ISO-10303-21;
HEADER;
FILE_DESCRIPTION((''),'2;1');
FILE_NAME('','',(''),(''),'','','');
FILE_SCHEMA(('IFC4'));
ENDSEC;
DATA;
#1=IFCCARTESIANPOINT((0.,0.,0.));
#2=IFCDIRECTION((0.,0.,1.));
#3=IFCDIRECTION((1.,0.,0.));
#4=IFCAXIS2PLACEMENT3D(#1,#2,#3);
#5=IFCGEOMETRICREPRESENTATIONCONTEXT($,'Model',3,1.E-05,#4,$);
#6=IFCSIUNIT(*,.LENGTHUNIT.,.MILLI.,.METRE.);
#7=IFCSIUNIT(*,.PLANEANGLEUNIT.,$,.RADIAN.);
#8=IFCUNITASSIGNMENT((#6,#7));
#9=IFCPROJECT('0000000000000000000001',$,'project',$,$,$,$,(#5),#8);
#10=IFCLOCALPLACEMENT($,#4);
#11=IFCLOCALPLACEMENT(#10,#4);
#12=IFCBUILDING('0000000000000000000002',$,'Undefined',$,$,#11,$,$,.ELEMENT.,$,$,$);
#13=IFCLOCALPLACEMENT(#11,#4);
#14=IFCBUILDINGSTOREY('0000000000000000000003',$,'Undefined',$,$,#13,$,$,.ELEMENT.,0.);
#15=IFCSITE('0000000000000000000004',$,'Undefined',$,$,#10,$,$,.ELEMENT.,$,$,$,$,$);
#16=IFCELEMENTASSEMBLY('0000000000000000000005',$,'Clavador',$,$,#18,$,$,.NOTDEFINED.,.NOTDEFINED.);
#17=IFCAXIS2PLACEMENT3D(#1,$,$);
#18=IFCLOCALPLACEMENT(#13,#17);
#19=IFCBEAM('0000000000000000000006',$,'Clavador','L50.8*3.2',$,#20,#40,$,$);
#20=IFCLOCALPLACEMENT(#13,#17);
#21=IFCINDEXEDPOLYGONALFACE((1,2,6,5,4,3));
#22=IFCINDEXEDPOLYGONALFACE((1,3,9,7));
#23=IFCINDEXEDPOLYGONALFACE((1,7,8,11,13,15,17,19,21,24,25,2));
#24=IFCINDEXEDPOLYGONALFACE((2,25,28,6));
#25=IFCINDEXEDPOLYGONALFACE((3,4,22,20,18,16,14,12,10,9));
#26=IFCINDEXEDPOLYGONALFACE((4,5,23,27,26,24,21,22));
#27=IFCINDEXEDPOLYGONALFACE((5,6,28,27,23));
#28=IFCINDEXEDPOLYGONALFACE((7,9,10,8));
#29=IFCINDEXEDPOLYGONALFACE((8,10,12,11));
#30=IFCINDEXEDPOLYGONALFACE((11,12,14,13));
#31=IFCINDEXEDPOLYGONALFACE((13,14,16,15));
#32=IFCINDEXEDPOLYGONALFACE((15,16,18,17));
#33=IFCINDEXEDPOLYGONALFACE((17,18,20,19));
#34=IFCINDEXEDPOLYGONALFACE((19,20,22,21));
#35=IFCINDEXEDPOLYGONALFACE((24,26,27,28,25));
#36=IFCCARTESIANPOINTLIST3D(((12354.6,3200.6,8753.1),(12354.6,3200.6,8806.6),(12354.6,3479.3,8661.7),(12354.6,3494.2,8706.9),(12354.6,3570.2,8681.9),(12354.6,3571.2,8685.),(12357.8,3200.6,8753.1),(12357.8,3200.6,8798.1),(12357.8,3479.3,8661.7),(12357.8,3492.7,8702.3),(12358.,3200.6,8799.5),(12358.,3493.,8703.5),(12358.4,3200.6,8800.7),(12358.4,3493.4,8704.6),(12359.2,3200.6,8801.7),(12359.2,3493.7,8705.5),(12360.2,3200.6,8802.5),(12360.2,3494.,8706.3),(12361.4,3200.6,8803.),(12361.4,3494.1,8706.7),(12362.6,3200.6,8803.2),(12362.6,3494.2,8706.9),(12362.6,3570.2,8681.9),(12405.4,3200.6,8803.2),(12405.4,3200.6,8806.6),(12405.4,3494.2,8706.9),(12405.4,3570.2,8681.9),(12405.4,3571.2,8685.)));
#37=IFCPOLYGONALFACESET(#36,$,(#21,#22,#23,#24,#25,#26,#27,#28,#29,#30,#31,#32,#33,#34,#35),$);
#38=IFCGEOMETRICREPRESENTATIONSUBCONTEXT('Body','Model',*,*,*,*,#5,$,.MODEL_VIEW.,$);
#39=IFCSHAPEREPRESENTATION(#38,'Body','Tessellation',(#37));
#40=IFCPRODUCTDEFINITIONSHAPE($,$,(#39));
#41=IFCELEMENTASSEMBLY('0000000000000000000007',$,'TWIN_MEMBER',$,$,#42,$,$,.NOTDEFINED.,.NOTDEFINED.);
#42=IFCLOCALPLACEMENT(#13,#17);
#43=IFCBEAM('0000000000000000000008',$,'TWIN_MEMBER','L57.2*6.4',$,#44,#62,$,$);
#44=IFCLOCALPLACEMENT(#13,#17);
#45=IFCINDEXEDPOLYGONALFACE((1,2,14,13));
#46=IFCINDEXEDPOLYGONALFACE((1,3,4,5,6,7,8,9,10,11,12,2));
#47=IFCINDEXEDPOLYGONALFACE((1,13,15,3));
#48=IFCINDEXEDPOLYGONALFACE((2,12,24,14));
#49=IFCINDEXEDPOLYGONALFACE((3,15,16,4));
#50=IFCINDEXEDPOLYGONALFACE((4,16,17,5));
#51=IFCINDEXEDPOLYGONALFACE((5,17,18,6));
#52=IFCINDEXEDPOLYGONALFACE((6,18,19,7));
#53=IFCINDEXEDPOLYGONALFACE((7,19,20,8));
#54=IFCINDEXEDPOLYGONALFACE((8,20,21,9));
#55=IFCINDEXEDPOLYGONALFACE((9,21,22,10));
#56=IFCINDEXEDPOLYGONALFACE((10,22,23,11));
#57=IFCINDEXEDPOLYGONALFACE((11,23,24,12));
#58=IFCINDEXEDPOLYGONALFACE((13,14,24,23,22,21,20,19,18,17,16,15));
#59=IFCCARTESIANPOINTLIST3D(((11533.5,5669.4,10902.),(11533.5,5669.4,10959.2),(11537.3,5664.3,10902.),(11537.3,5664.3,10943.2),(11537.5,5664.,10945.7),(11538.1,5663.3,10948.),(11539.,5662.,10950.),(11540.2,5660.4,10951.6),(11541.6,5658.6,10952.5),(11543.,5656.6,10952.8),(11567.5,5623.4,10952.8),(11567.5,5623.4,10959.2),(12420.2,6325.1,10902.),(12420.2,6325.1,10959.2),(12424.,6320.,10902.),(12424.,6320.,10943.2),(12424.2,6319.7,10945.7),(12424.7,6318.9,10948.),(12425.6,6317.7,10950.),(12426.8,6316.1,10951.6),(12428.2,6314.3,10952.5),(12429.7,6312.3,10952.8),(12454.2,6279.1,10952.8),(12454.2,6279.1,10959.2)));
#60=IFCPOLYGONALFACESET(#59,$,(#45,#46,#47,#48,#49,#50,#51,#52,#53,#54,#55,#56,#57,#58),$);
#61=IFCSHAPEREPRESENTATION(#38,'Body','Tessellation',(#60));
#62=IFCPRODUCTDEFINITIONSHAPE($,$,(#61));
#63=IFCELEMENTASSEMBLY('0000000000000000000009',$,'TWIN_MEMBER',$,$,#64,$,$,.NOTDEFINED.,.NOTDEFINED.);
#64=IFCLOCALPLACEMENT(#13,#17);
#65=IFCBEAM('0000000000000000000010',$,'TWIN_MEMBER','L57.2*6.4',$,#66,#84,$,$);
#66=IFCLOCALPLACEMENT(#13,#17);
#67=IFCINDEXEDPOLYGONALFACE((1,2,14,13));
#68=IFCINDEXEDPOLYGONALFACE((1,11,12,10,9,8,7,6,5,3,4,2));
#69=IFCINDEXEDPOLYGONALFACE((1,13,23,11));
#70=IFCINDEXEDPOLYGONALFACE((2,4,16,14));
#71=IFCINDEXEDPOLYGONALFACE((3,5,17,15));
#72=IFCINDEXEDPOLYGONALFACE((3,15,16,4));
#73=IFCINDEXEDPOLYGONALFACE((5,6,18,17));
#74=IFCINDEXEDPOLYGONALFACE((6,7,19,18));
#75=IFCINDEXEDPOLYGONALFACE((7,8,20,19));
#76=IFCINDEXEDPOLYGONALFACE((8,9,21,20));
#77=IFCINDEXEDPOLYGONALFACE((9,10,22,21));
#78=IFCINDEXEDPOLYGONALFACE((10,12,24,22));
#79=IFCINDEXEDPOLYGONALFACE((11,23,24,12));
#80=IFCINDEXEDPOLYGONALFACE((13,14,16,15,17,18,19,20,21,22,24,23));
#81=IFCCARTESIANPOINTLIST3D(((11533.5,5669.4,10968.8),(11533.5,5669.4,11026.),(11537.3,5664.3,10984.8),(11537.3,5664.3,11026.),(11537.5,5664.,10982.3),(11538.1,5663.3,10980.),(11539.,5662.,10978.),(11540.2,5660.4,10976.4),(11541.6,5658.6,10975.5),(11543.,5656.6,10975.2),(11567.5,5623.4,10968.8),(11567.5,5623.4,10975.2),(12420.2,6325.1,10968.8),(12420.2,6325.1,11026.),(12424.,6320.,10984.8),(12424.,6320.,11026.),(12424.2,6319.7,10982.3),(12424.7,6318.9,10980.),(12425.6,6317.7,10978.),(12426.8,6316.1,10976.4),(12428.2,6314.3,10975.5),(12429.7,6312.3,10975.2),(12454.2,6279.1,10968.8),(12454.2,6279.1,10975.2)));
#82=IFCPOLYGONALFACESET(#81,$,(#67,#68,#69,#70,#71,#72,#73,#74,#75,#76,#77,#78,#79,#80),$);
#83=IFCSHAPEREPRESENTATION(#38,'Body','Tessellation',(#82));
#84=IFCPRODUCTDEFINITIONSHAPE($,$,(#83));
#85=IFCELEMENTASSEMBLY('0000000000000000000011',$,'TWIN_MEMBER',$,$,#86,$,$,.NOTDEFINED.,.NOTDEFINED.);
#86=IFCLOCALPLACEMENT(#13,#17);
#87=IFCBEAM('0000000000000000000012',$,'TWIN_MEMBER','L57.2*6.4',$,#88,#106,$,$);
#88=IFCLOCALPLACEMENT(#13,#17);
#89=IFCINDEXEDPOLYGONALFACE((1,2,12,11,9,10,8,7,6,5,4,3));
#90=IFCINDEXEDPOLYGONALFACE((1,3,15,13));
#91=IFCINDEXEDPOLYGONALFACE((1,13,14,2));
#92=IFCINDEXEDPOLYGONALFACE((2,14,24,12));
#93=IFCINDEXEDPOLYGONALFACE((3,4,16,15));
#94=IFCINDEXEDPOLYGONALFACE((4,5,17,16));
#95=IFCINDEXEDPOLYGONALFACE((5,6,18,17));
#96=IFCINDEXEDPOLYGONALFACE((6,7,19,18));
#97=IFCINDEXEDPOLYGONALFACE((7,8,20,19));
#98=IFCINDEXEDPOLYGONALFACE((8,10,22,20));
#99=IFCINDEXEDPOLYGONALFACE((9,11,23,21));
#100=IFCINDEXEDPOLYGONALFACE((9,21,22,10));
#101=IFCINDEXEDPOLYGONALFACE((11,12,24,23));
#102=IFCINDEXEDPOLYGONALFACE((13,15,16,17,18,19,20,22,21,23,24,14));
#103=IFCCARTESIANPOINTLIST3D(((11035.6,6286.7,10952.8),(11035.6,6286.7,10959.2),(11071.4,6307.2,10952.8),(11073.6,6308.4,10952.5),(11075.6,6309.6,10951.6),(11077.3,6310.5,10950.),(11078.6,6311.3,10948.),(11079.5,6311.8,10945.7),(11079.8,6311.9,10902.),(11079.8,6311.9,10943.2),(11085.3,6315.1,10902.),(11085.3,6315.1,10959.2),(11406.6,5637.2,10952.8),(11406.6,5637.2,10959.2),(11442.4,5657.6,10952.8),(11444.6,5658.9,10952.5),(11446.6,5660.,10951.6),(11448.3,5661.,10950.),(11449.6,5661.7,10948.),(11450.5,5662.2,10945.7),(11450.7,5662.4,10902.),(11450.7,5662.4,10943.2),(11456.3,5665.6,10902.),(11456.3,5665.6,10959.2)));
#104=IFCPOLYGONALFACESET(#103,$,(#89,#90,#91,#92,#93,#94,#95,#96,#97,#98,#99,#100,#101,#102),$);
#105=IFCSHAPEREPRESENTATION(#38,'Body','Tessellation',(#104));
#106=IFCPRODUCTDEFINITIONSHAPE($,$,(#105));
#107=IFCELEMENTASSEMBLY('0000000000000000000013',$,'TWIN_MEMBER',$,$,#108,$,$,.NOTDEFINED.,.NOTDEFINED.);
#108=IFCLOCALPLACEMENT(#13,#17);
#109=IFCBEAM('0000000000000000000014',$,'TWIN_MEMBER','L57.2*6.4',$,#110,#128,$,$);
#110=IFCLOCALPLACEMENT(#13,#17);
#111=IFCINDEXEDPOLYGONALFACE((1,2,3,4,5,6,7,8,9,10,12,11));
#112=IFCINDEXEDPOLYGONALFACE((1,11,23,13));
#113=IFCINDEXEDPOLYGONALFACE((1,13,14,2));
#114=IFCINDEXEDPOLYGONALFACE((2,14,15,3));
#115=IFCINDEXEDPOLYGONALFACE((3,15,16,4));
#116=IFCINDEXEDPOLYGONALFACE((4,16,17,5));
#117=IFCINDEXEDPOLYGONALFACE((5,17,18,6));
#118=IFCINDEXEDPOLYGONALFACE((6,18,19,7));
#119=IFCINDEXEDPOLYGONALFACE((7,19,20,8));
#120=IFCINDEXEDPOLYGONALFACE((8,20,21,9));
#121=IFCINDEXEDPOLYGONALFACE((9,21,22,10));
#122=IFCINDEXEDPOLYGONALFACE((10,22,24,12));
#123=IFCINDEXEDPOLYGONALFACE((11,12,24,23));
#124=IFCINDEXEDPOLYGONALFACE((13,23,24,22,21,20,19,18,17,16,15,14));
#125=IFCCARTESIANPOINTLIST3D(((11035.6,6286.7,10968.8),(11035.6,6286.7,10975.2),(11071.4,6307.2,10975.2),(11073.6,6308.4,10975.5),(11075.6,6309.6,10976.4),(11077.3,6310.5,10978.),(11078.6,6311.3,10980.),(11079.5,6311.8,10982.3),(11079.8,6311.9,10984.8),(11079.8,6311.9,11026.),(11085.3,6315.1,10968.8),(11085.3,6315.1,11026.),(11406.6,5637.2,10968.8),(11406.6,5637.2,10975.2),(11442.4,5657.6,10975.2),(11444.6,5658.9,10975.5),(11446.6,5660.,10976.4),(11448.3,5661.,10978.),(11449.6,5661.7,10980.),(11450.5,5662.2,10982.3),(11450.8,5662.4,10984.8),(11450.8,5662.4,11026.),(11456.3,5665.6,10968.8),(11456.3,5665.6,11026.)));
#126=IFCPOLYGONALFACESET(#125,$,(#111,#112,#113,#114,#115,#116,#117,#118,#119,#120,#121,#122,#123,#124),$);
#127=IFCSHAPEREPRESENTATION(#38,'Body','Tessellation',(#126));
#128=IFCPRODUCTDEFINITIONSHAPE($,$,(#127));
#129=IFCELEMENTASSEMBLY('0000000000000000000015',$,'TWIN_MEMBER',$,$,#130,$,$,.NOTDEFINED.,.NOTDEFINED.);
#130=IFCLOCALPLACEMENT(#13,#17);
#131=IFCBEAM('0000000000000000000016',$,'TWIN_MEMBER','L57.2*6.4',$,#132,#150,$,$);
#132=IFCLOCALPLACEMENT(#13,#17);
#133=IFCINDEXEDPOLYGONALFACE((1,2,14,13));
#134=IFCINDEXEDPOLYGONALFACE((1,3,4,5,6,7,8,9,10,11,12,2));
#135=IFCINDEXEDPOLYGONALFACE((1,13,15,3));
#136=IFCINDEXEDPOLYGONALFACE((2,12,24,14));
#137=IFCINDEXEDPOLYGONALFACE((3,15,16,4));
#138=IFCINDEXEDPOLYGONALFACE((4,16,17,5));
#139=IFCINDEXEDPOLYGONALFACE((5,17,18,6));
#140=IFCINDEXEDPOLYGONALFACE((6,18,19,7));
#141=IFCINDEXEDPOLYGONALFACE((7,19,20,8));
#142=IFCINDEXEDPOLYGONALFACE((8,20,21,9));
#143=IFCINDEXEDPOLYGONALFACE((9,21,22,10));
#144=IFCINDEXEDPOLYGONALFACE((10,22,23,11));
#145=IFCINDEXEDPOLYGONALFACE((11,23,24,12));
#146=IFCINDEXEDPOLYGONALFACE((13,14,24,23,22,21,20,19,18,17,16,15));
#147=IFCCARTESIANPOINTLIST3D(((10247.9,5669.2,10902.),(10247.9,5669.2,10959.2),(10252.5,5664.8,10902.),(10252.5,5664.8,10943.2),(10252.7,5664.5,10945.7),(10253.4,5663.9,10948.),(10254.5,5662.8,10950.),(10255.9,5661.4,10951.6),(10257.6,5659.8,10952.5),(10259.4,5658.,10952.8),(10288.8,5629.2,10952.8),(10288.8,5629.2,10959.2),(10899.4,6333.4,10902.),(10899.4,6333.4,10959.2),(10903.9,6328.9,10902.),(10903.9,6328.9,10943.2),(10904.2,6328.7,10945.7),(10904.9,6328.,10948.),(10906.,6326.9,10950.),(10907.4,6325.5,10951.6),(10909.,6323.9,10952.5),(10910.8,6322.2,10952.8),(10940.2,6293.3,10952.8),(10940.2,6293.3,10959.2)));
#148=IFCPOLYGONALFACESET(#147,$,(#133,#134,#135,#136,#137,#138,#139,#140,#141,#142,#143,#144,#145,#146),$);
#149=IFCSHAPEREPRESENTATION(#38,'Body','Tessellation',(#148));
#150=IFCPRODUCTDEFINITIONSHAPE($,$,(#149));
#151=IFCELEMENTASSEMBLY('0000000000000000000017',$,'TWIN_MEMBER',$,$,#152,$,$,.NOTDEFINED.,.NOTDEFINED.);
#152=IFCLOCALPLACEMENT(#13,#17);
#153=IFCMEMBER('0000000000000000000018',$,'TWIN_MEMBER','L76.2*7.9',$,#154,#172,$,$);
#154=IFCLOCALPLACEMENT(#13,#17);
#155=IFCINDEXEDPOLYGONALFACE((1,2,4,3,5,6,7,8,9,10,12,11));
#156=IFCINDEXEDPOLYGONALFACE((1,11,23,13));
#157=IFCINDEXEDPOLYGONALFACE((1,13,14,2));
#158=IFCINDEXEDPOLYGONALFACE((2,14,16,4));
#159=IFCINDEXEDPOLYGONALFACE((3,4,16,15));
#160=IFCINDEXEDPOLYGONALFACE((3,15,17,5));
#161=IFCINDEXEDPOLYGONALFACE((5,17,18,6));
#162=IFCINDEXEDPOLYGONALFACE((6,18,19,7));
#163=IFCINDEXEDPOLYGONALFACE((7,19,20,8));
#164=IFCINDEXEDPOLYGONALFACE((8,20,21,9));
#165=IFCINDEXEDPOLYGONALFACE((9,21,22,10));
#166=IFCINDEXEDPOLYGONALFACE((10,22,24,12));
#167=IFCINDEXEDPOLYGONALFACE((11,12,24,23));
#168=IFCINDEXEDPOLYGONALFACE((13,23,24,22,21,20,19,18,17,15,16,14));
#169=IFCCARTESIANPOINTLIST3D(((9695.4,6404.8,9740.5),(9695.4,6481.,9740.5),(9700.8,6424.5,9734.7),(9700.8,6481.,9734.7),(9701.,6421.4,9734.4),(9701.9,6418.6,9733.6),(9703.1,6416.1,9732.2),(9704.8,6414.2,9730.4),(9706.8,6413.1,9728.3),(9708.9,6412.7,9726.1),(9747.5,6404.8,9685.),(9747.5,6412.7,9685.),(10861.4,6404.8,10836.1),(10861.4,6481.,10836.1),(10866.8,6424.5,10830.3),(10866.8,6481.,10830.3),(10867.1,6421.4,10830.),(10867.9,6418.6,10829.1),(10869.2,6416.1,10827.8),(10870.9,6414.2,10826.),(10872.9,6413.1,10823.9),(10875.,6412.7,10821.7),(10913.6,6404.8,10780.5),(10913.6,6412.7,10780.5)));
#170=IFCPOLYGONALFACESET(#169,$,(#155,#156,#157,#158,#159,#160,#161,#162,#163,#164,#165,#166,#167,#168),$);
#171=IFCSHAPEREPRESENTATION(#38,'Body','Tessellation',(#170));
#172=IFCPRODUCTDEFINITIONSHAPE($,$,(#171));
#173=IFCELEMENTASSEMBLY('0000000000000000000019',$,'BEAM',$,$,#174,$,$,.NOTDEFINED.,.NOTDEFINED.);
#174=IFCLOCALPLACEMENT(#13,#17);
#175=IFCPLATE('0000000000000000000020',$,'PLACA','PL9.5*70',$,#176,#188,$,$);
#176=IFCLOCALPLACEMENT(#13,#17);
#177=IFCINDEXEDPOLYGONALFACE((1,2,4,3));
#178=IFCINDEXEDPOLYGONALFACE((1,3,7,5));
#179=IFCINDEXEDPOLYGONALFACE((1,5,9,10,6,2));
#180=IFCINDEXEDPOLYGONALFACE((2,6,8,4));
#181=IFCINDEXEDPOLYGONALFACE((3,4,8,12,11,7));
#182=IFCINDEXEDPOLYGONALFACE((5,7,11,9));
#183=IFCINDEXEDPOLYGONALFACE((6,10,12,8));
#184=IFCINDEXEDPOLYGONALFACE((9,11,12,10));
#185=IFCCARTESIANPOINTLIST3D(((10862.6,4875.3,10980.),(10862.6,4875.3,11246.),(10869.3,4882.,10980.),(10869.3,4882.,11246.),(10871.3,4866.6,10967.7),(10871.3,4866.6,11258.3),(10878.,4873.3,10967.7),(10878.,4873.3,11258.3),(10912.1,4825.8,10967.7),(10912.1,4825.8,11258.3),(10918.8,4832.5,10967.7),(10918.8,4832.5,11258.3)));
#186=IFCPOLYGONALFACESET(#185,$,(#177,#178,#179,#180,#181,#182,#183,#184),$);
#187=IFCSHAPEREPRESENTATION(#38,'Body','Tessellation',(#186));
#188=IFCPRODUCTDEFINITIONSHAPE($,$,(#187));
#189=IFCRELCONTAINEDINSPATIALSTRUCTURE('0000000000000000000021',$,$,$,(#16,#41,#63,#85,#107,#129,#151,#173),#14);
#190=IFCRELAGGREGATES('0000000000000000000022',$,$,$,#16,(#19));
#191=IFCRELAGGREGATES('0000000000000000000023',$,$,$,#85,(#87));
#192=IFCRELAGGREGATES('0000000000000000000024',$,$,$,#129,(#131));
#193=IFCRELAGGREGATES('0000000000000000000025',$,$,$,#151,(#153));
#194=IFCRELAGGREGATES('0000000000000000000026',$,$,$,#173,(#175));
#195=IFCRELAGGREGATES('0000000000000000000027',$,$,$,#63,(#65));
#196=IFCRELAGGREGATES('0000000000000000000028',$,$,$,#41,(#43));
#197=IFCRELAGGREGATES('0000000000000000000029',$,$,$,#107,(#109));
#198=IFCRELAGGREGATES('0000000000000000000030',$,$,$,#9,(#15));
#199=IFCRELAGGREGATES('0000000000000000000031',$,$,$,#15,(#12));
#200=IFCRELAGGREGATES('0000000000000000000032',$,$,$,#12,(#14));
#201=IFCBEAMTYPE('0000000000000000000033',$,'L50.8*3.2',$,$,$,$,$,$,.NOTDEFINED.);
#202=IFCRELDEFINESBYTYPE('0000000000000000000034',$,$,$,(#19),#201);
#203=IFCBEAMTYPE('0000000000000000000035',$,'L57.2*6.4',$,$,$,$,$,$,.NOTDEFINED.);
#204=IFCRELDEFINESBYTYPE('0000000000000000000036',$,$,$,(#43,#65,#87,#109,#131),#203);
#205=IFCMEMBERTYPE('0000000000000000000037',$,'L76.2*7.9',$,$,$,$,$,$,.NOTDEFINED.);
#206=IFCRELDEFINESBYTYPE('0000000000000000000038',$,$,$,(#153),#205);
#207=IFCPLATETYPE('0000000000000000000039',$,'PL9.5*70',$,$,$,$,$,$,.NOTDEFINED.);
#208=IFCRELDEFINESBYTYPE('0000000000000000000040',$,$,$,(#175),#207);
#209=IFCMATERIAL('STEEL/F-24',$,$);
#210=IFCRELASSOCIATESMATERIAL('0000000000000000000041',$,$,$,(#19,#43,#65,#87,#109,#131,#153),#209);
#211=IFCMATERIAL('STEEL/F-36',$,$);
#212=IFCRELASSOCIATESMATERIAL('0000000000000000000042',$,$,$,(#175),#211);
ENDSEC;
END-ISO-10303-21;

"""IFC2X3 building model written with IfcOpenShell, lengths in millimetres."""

from ifc_helpers import new_model, si_unit, frame, origin_with_axes, origin_2d_with_axis, place, context, subcontext, project, spatial, polyline, l_section, outline, extrude, boolean, halfspace, material, type_object, element, aggregate, save


model = new_model("IFC2X3")

# Units and contexts
model_context = context("Model", 3, precision=1e-05, world=origin_with_axes())
body_context = subcontext(model_context, "Body", "Model", "MODEL_VIEW")
ifc_project = project(units=[si_unit("LENGTHUNIT", "METRE", prefix="MILLI"), si_unit("PLANEANGLEUNIT", "RADIAN")], contexts=[model_context])

# Site, building, storey
site_placement = place(None, origin_with_axes())
site = spatial("IfcSite", under=ifc_project, at=site_placement, Name="Undefined", CompositionType="ELEMENT")
building_placement = place(site_placement, origin_with_axes())
building = spatial("IfcBuilding", under=site, at=building_placement, Name="Undefined", CompositionType="ELEMENT")
storey_placement = place(building_placement, origin_with_axes())
storey = spatial("IfcBuildingStorey", under=building, at=storey_placement, Name="Undefined", CompositionType="ELEMENT", Elevation=0.0)

# Shared definitions
ifc_material_1 = material(Name="STEEL/F-24")
beam_type_1 = type_object("IfcBeamType", Name="L50.8*3.2", PredefinedType="NOTDEFINED")

# Element assembly, beam
assembly_1_placement = place(storey_placement, origin_with_axes())
assembly_1 = element("IfcElementAssembly", 1, at=assembly_1_placement, inside=storey, Name="Clavador", AssemblyPlace="NOTDEFINED", PredefinedType="NOTDEFINED")
beam_1_placement = place(assembly_1_placement, frame((12380.0, 3563.2, 8660.8), z_axis=(0.0, -0.311771, -0.950157), x_axis=(0.0, -0.950157, 0.311771)))
beam_1 = element("IfcBeam", 2, at=beam_1_placement, type_object=beam_type_1, material=ifc_material_1, Name="Clavador", Description="L50.8*3.2", context=body_context, shape_type="CSG", body=[
    boolean("DIFFERENCE", boolean("DIFFERENCE", extrude(l_section(Depth=50.8, Width=50.8, Thickness=3.2, FilletRadius=4.8, at=origin_2d_with_axis()), frame((397.4, 0.0, 0.0), z_axis=(-1.0, 0.0, 0.0), x_axis=(0.0, -1.0, 0.0)), (0.0, 0.0, 1.0), 397.4), extrude(outline(polyline([(0.0, 0.0), (47.6, 0.0), (47.6, 80.0), (0.0, 80.0), (0.0, 0.0)])), frame((0.0, -28.0, -22.2), z_axis=(0.0, 1.0, 0.0), x_axis=(0.0, 0.0, 1.0)), (0.0, 0.0, 1.0), 56.0)), halfspace(frame((390.0, 0.0, -25.4), z_axis=(-0.950157, 0.0, -0.311771), x_axis=(0.0, 1.0, 0.0)), True)),
])
aggregate(assembly_1, [beam_1])

# Element assemblies, beams
assembly_2_placement = place(storey_placement, origin_with_axes())
assembly_2 = element("IfcElementAssembly", 3, at=assembly_2_placement, inside=storey, Name="TWIN_MEMBER", AssemblyPlace="NOTDEFINED", PredefinedType="NOTDEFINED")
beam_type_2 = type_object("IfcBeamType", Name="L57.2*6.4", PredefinedType="NOTDEFINED")
beam_2_placement = place(assembly_2_placement, frame((12437.2, 6302.1, 10930.6), z_axis=(0.0, 0.0, -1.0), x_axis=(-0.804024, -0.594597, 0.0)))
beam_2 = element("IfcBeam", 4, at=beam_2_placement, type_object=beam_type_2, material=ifc_material_1, Name="TWIN_MEMBER", Description="L57.2*6.4", context=body_context, shape_type="SweptSolid", body=[
    extrude(l_section(Depth=57.2, Width=57.2, Thickness=6.4, FilletRadius=9.6, at=origin_2d_with_axis()), frame((1102.7, 0.0, 0.0), z_axis=(-1.0, 0.0, 0.0), x_axis=(0.0, -1.0, 0.0)), (0.0, 0.0, 1.0), 1102.7),
])
assembly_3_placement = place(storey_placement, origin_with_axes())
assembly_3 = element("IfcElementAssembly", 5, at=assembly_3_placement, inside=storey, Name="TWIN_MEMBER", AssemblyPlace="NOTDEFINED", PredefinedType="NOTDEFINED")
beam_3_placement = place(assembly_3_placement, frame((11550.5, 5646.4, 10997.4), z_axis=(0.0, 0.0, 1.0), x_axis=(0.804024, 0.594597, 0.0)))
beam_3 = element("IfcBeam", 6, at=beam_3_placement, type_object=beam_type_2, material=ifc_material_1, Name="TWIN_MEMBER", Description="L57.2*6.4", context=body_context, shape_type="SweptSolid", body=[
    extrude(l_section(Depth=57.2, Width=57.2, Thickness=6.4, FilletRadius=9.6, at=origin_2d_with_axis()), frame((1102.7, 0.0, 0.0), z_axis=(-1.0, 0.0, 0.0), x_axis=(0.0, -1.0, 0.0)), (0.0, 0.0, 1.0), 1102.7),
])
assembly_4_placement = place(storey_placement, origin_with_axes())
assembly_4 = element("IfcElementAssembly", 7, at=assembly_4_placement, inside=storey, Name="TWIN_MEMBER", AssemblyPlace="NOTDEFINED", PredefinedType="NOTDEFINED")
beam_4_placement = place(assembly_4_placement, frame((11431.5, 5651.4, 10930.6), z_axis=(0.0, 0.0, -1.0), x_axis=(-0.495959, 0.868346, 0.0)))
beam_4 = element("IfcBeam", 8, at=beam_4_placement, type_object=beam_type_2, material=ifc_material_1, Name="TWIN_MEMBER", Description="L57.2*6.4", context=body_context, shape_type="SweptSolid", body=[
    extrude(l_section(Depth=57.2, Width=57.2, Thickness=6.4, FilletRadius=9.6, at=origin_2d_with_axis()), frame((748.0, 0.0, 0.0), z_axis=(-1.0, 0.0, 0.0), x_axis=(0.0, -1.0, 0.0)), (0.0, 0.0, 1.0), 748.0),
])
aggregate(assembly_4, [beam_4])
assembly_5_placement = place(storey_placement, origin_with_axes())
assembly_5 = element("IfcElementAssembly", 9, at=assembly_5_placement, inside=storey, Name="TWIN_MEMBER", AssemblyPlace="NOTDEFINED", PredefinedType="NOTDEFINED")
beam_5_placement = place(assembly_5_placement, frame((11060.5, 6300.9, 10997.4), z_axis=(0.0, 0.0, 1.0), x_axis=(0.495959, -0.868346, 0.0)))
beam_5 = element("IfcBeam", 10, at=beam_5_placement, type_object=beam_type_2, material=ifc_material_1, Name="TWIN_MEMBER", Description="L57.2*6.4", context=body_context, shape_type="SweptSolid", body=[
    extrude(l_section(Depth=57.2, Width=57.2, Thickness=6.4, FilletRadius=9.6, at=origin_2d_with_axis()), frame((748.0, 0.0, 0.0), z_axis=(-1.0, 0.0, 0.0), x_axis=(0.0, -1.0, 0.0)), (0.0, 0.0, 1.0), 748.0),
])
assembly_6_placement = place(storey_placement, origin_with_axes())
assembly_6 = element("IfcElementAssembly", 11, at=assembly_6_placement, inside=storey, Name="TWIN_MEMBER", AssemblyPlace="NOTDEFINED", PredefinedType="NOTDEFINED")
beam_6_placement = place(assembly_6_placement, frame((10919.8, 6313.4, 10930.6), z_axis=(0.0, 0.0, -1.0), x_axis=(-0.700239, -0.713908, 0.0)))
beam_6 = element("IfcBeam", 12, at=beam_6_placement, type_object=beam_type_2, material=ifc_material_1, Name="TWIN_MEMBER", Description="L57.2*6.4", context=body_context, shape_type="SweptSolid", body=[
    extrude(l_section(Depth=57.2, Width=57.2, Thickness=6.4, FilletRadius=9.6, at=origin_2d_with_axis()), frame((930.3, 0.0, 0.0), z_axis=(-1.0, 0.0, 0.0), x_axis=(0.0, -1.0, 0.0)), (0.0, 0.0, 1.0), 930.3),
])
aggregate(assembly_6, [beam_6])

# Element assembly, member
assembly_7_placement = place(storey_placement, origin_with_axes())
assembly_7 = element("IfcElementAssembly", 13, at=assembly_7_placement, inside=storey, Name="TWIN_MEMBER", AssemblyPlace="NOTDEFINED", PredefinedType="NOTDEFINED")
member_type = type_object("IfcMemberType", Name="L76.2*7.9", PredefinedType="NOTDEFINED")
member_placement = place(assembly_7_placement, frame((10887.5, 6442.9, 10808.3), z_axis=(0.0, 1.0, 0.0), x_axis=(-0.728798, 0.0, -0.684729)))
member = element("IfcMember", 14, at=member_placement, type_object=member_type, material=ifc_material_1, Name="TWIN_MEMBER", Description="L76.2*7.9", context=body_context, shape_type="SweptSolid", body=[
    extrude(l_section(Depth=76.2, Width=76.2, Thickness=7.9, FilletRadius=11.8, at=origin_2d_with_axis()), frame((1600.0, 0.0, 0.0), z_axis=(-1.0, 0.0, 0.0), x_axis=(0.0, -1.0, 0.0)), (0.0, 0.0, 1.0), 1600.0),
])
aggregate(assembly_7, [member])

# Element assembly, plate
assembly_8_placement = place(storey_placement, origin_with_axes())
assembly_8 = element("IfcElementAssembly", 15, at=assembly_8_placement, inside=storey, Name="BEAM", AssemblyPlace="NOTDEFINED", PredefinedType="NOTDEFINED")
ifc_material_2 = material(Name="STEEL/F-36")
plate_type_1 = type_object("IfcPlateType", Name="PL9.5*70", PredefinedType="NOTDEFINED")
plate_1_placement = place(assembly_8_placement, frame((10865.9, 4878.6, 10967.7), z_axis=(-0.707107, -0.707106, 0.0), x_axis=(0.707106, -0.707107, 0.0)))
plate_1 = element("IfcPlate", 16, at=plate_1_placement, type_object=plate_type_1, material=ifc_material_2, Name="PLACA", Description="PL9.5*70", context=body_context, shape_type="SweptSolid", body=[
    extrude(outline(polyline([(0.0, 12.3), (12.3, 0.0), (70.0, 0.0), (70.0, 290.6), (12.3, 290.6), (0.0, 278.3), (0.0, 12.3)])), frame((0.0, 0.0, -4.8), z_axis=(0.0, 0.0, 1.0), x_axis=(1.0, 0.0, 0.0)), (0.0, 0.0, 1.0), 9.5),
])
aggregate(assembly_8, [plate_1])

aggregate(assembly_3, [beam_3])
aggregate(assembly_2, [beam_2])

aggregate(assembly_5, [beam_5])

save(model, "model.ifc")
